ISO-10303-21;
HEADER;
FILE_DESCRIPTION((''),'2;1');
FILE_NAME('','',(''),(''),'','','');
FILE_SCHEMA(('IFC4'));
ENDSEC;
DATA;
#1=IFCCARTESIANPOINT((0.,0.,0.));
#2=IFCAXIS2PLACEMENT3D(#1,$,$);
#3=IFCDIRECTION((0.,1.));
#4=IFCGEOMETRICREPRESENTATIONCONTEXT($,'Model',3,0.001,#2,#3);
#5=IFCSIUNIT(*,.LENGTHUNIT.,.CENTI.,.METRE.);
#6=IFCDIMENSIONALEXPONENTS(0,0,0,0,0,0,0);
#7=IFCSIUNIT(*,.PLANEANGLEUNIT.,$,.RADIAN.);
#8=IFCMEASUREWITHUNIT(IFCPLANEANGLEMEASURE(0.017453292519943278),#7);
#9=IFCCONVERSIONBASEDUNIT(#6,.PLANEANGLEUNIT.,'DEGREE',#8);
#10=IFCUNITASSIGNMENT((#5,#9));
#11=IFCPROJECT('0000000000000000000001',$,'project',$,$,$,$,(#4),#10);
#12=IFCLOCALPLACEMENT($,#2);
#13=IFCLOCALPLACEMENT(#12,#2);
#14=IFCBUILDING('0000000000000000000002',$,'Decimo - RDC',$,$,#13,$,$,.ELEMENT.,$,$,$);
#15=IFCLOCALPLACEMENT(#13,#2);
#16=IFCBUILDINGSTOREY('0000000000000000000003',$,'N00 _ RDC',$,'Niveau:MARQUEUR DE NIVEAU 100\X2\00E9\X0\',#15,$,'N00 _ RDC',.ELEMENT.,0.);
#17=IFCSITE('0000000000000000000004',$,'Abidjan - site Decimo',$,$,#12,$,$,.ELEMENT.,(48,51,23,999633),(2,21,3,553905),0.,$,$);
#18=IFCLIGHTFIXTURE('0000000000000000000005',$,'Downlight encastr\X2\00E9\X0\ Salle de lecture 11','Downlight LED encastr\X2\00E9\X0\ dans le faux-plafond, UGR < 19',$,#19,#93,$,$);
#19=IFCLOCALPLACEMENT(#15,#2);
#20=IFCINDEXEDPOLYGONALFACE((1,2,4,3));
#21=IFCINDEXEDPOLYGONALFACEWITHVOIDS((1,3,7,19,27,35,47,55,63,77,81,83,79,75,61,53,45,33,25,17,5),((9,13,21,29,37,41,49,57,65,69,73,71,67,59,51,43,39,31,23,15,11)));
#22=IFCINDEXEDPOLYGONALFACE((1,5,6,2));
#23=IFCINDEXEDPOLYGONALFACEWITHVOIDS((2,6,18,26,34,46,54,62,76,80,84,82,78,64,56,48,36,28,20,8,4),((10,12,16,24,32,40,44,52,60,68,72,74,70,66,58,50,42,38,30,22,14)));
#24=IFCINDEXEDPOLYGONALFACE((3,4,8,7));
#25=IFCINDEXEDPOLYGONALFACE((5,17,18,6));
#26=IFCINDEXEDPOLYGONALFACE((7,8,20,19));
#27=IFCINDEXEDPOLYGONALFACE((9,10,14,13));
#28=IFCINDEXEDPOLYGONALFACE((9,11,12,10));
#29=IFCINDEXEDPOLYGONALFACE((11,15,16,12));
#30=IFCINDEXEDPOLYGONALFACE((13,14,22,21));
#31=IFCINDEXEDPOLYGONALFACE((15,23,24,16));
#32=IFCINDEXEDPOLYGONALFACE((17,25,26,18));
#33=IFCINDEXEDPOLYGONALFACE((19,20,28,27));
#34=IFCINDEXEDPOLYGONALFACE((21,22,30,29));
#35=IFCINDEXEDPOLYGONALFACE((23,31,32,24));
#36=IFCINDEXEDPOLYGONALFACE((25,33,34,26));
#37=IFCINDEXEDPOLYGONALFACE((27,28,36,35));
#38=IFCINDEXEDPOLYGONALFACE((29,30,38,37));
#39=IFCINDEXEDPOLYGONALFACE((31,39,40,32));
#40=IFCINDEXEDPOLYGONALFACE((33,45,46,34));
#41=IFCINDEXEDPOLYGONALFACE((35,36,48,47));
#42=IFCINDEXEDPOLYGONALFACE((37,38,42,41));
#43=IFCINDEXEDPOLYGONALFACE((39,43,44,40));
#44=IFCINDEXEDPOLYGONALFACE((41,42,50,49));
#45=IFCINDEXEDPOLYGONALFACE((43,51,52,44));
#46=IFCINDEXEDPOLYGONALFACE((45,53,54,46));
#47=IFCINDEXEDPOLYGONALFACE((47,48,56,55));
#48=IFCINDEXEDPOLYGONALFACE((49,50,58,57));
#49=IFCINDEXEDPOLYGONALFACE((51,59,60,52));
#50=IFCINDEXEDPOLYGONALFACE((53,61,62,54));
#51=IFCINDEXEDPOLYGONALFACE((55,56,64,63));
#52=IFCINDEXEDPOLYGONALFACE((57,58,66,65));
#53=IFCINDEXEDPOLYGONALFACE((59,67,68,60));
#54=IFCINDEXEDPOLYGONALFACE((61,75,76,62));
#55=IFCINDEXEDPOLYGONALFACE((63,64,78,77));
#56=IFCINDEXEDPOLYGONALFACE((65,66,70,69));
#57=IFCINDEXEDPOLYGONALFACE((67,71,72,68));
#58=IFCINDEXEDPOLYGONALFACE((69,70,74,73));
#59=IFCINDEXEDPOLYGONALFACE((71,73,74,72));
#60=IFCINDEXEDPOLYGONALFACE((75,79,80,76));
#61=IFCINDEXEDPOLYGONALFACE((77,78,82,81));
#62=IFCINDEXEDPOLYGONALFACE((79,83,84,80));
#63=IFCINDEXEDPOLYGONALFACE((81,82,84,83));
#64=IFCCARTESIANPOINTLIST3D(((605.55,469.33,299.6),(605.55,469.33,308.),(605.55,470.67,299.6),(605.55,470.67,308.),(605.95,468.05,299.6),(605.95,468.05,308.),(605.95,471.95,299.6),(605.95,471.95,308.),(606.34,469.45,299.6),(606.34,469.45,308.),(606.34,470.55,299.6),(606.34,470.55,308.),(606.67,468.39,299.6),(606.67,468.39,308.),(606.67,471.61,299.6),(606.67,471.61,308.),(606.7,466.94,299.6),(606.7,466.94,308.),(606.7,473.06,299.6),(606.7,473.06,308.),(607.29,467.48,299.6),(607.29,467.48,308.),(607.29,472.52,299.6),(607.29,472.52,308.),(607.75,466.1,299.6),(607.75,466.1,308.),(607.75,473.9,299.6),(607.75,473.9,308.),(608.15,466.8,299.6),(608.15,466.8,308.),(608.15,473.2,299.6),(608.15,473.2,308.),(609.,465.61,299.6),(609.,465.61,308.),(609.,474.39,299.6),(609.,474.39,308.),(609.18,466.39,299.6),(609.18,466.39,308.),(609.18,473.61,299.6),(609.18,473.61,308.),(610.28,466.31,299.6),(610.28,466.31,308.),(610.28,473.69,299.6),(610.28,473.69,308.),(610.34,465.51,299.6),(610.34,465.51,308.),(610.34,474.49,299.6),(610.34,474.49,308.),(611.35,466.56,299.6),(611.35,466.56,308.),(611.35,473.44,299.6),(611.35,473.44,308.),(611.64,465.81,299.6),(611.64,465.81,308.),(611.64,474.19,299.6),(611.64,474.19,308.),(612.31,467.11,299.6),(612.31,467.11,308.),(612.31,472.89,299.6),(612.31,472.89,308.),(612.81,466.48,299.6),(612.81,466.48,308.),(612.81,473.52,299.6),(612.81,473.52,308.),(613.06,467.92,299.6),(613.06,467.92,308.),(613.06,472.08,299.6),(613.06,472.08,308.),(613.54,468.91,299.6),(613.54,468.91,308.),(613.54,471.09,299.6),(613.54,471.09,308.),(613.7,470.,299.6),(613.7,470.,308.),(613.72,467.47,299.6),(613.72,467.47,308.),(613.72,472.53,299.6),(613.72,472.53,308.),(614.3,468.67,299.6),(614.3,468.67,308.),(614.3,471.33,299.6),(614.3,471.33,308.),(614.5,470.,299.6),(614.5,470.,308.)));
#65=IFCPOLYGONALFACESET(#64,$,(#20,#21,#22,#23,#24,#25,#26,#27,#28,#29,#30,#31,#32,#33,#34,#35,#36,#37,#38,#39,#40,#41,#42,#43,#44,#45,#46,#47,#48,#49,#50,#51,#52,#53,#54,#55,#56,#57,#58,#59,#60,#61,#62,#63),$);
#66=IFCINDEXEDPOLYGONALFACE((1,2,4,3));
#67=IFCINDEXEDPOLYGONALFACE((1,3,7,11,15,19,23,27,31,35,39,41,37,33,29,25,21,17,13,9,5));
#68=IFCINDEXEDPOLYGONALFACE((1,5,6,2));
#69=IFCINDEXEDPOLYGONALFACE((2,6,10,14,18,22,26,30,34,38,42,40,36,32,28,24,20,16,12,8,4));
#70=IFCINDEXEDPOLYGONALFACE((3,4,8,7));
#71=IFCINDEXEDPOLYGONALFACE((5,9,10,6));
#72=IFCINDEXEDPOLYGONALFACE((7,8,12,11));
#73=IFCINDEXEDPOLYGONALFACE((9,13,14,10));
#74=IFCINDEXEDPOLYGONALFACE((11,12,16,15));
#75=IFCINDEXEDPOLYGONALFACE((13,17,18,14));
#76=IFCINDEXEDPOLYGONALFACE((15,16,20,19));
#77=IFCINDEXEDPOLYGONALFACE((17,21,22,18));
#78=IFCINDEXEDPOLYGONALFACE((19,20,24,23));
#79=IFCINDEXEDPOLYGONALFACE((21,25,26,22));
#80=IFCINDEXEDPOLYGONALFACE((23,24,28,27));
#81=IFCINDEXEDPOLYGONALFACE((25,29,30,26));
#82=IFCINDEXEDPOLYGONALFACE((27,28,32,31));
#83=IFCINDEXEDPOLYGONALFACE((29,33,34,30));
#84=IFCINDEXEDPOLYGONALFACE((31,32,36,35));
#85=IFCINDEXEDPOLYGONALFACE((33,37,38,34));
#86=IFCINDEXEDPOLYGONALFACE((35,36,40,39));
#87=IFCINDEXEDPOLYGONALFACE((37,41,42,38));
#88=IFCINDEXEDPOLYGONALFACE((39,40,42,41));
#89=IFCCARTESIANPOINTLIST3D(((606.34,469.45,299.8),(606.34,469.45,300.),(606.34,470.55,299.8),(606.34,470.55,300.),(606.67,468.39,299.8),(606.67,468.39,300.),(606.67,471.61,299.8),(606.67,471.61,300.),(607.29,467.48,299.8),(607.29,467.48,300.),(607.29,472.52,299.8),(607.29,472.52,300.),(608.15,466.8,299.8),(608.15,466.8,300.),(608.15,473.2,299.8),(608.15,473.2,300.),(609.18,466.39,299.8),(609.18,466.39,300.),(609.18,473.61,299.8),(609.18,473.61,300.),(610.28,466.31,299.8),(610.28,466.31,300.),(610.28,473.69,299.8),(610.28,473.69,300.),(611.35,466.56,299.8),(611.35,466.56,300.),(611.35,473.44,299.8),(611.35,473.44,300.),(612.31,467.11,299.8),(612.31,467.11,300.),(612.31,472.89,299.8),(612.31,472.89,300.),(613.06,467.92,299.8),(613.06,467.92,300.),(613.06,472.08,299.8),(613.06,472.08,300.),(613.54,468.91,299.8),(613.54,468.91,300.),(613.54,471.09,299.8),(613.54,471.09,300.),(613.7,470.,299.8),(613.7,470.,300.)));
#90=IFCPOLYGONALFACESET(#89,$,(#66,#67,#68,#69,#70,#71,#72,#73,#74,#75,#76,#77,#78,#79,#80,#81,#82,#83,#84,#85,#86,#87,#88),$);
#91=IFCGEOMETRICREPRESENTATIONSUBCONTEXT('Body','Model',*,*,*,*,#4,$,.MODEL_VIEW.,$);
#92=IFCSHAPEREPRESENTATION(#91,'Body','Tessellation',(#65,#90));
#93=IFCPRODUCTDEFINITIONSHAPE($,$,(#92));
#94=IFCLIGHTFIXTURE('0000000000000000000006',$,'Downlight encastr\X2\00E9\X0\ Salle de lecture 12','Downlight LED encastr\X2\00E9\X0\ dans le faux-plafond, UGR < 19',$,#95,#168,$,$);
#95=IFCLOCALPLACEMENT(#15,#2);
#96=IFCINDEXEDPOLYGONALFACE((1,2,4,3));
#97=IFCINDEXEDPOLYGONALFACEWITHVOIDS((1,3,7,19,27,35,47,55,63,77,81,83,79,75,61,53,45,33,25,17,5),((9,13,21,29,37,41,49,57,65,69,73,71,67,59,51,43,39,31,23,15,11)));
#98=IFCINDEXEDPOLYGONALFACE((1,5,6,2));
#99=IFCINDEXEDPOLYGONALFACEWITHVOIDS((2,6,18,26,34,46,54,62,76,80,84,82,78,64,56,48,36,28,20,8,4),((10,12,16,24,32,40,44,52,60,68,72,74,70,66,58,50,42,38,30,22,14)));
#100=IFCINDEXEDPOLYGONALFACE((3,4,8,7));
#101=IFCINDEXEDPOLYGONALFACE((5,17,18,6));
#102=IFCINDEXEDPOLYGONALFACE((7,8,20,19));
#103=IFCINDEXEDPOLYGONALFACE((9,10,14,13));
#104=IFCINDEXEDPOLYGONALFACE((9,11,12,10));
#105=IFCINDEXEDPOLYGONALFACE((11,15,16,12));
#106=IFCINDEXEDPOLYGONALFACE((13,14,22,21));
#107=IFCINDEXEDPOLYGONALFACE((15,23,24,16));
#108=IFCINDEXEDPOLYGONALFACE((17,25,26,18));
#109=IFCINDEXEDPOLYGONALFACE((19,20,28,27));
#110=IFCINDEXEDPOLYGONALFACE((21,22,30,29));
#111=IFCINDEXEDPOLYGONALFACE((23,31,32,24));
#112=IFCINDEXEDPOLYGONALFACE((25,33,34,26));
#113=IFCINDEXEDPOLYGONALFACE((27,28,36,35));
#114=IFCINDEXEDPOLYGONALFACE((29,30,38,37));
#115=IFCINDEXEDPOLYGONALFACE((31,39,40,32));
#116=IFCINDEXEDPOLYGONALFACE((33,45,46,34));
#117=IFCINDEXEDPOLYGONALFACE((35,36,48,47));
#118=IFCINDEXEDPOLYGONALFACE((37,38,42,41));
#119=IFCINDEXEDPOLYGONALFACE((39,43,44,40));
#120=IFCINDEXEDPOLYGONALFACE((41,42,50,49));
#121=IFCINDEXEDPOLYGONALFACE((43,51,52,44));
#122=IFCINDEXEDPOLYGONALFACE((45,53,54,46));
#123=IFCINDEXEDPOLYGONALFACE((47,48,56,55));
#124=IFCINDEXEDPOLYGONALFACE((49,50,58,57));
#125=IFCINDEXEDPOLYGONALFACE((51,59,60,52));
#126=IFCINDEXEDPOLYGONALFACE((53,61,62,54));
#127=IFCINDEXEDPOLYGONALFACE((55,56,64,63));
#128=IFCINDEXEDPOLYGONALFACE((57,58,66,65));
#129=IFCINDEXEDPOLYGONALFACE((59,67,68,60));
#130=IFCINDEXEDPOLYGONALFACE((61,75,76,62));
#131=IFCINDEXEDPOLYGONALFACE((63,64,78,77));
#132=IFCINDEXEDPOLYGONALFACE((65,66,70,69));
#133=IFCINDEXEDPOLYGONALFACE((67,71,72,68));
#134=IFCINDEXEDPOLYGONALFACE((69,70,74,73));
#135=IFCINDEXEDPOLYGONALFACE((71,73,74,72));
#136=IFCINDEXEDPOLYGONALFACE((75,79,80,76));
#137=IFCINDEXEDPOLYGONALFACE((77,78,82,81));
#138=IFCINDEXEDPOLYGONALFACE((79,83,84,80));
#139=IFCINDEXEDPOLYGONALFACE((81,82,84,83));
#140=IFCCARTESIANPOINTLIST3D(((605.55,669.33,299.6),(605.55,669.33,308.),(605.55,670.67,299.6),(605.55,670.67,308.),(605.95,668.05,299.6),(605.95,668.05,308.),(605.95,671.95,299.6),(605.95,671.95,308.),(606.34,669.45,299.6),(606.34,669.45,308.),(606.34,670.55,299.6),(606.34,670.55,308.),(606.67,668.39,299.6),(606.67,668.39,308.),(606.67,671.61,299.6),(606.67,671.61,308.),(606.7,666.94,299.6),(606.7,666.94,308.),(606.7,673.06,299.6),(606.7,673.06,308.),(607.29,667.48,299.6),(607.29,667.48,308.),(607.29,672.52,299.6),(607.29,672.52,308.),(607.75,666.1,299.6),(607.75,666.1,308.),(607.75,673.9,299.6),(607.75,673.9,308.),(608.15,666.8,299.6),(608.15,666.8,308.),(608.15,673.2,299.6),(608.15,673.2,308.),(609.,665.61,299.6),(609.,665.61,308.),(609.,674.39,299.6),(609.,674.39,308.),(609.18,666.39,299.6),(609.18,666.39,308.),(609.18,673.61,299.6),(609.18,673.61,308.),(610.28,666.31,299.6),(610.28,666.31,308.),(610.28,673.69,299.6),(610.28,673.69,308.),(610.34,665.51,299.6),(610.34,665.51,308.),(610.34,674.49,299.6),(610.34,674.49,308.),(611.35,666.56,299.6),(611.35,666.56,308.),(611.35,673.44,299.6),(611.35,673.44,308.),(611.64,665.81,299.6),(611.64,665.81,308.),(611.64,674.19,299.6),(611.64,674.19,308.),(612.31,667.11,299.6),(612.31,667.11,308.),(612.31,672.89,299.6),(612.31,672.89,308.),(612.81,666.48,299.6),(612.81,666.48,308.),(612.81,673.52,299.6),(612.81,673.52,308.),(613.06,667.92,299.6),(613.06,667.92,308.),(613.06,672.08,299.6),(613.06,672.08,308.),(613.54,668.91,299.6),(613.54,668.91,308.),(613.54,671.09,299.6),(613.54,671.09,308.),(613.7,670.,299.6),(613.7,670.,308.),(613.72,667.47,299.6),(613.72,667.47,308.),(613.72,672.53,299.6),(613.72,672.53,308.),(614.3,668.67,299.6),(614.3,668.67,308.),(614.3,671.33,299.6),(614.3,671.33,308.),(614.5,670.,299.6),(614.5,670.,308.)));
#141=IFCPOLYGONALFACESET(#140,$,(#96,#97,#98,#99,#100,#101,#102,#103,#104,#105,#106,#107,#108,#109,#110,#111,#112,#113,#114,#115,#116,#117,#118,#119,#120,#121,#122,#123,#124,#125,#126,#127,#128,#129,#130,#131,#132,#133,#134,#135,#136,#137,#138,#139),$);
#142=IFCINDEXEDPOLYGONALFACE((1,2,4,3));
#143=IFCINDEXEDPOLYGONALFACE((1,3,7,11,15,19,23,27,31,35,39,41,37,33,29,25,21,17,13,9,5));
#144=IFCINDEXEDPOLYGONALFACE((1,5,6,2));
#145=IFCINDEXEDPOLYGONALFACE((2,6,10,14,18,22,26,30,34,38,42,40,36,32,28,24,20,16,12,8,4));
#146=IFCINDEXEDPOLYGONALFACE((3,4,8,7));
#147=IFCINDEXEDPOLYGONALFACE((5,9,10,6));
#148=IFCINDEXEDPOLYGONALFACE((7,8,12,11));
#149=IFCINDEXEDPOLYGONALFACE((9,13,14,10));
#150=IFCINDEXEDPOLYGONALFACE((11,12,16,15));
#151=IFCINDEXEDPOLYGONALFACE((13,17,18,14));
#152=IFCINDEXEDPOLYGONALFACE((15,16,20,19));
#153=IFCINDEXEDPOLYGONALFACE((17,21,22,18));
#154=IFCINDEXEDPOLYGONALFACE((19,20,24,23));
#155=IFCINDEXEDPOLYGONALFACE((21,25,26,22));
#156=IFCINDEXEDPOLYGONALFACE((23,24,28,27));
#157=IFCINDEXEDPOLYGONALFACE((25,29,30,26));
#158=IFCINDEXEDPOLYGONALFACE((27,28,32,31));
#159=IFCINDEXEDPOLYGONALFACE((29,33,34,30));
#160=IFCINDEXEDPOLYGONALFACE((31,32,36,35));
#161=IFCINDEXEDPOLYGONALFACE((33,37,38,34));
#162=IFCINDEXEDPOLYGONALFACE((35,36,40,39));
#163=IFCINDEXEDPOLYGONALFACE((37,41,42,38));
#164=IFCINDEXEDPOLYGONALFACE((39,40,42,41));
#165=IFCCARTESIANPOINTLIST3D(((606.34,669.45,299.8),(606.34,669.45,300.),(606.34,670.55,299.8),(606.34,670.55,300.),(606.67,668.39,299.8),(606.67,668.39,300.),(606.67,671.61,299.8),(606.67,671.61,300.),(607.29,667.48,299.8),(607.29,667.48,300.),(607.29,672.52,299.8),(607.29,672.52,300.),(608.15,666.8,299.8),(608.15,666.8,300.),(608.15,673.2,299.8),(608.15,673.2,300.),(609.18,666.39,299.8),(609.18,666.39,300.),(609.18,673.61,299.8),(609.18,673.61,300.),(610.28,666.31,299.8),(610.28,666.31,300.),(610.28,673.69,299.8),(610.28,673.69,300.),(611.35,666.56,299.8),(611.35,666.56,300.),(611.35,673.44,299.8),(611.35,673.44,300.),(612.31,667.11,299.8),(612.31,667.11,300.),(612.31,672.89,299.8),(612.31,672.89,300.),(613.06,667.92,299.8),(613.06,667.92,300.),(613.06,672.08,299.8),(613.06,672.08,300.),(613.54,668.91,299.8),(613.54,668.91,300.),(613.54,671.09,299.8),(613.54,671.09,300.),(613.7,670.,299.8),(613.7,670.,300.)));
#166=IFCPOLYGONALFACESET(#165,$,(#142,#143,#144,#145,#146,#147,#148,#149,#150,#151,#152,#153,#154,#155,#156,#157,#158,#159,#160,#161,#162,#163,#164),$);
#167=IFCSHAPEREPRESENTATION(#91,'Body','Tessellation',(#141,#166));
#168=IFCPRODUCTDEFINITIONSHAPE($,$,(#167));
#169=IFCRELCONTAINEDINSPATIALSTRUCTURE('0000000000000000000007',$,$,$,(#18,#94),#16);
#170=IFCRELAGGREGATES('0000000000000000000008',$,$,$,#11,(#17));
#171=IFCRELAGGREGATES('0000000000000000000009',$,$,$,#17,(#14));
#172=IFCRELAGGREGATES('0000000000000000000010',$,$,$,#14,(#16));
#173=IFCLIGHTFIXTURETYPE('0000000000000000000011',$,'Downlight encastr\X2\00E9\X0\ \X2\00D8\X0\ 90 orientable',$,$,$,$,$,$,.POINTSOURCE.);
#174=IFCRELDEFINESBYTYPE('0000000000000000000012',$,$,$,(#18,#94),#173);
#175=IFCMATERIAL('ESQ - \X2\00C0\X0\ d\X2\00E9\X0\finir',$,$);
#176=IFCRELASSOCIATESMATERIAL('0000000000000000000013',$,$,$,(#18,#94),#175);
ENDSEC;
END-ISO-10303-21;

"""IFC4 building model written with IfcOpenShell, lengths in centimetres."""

from ifc_helpers import new_model, entity, si_unit, converted_unit, direction, frame, frame_2d, origin, origin_with_axes, place, context, subcontext, project, spatial, circle, hollow_circle, extrude, material, type_object, element, save


model = new_model("IFC4")

# Units and contexts
model_context = context("Model", 3, precision=0.001, world=origin(), true_north=direction((0.0, 1.0)))
body_context = subcontext(model_context, "Body", "Model", "MODEL_VIEW")
ifc_project = project(units=[si_unit("LENGTHUNIT", "METRE", prefix="CENTI"), converted_unit("PLANEANGLEUNIT", "DEGREE", entity("IfcPlaneAngleMeasure", 0.017453292519943278), si_unit("PLANEANGLEUNIT", "RADIAN"), dimensions=[0, 0, 0, 0, 0, 0, 0])], contexts=[model_context])

# Site, building, storey
site_placement = place(None, origin())
site = spatial("IfcSite", under=ifc_project, at=site_placement, Name="Abidjan - site Decimo", CompositionType="ELEMENT", RefLatitude=(48, 51, 23, 999633), RefLongitude=(2, 21, 3, 553905), RefElevation=0.0)
building_placement = place(site_placement, origin())
building = spatial("IfcBuilding", under=site, at=building_placement, Name="Decimo - RDC", CompositionType="ELEMENT")
storey_placement = place(building_placement, origin())
storey = spatial("IfcBuildingStorey", under=building, at=storey_placement, Name="N00 _ RDC", ObjectType="Niveau:MARQUEUR DE NIVEAU 100é", LongName="N00 _ RDC", CompositionType="ELEMENT", Elevation=0.0)

# Light fixtures
ifc_material_1 = material(Name="ESQ - À définir")
light_fixture_type_1 = type_object("IfcLightFixtureType", Name="Downlight encastré Ø 90 orientable", PredefinedType="POINTSOURCE")
light_fixture_1_placement = place(storey_placement, origin_with_axes())
element("IfcLightFixture", 1, at=light_fixture_1_placement, inside=storey, type_object=light_fixture_type_1, material=ifc_material_1, Name="Downlight encastré Salle de lecture 11", Description="Downlight LED encastré dans le faux-plafond, UGR < 19", context=body_context, shape_type="SweptSolid", body=[
    extrude(hollow_circle(Radius=4.5, WallThickness=0.8, at=frame_2d((610.0, 470.0))), frame((0.0, 0.0, 299.6)), (0.0, 0.0, 1.0), 8.4),
    extrude(circle(Radius=3.7, at=frame_2d((610.0, 470.0))), frame((0.0, 0.0, 299.8)), (0.0, 0.0, 1.0), 0.2),
])
light_fixture_2_placement = place(storey_placement, origin_with_axes())
element("IfcLightFixture", 2, at=light_fixture_2_placement, inside=storey, type_object=light_fixture_type_1, material=ifc_material_1, Name="Downlight encastré Salle de lecture 12", Description="Downlight LED encastré dans le faux-plafond, UGR < 19", context=body_context, shape_type="SweptSolid", body=[
    extrude(hollow_circle(Radius=4.5, WallThickness=0.8, at=frame_2d((610.0, 670.0))), frame((0.0, 0.0, 299.6)), (0.0, 0.0, 1.0), 8.4),
    extrude(circle(Radius=3.7, at=frame_2d((610.0, 670.0))), frame((0.0, 0.0, 299.8)), (0.0, 0.0, 1.0), 0.2),
])

save(model, "model.ifc")
